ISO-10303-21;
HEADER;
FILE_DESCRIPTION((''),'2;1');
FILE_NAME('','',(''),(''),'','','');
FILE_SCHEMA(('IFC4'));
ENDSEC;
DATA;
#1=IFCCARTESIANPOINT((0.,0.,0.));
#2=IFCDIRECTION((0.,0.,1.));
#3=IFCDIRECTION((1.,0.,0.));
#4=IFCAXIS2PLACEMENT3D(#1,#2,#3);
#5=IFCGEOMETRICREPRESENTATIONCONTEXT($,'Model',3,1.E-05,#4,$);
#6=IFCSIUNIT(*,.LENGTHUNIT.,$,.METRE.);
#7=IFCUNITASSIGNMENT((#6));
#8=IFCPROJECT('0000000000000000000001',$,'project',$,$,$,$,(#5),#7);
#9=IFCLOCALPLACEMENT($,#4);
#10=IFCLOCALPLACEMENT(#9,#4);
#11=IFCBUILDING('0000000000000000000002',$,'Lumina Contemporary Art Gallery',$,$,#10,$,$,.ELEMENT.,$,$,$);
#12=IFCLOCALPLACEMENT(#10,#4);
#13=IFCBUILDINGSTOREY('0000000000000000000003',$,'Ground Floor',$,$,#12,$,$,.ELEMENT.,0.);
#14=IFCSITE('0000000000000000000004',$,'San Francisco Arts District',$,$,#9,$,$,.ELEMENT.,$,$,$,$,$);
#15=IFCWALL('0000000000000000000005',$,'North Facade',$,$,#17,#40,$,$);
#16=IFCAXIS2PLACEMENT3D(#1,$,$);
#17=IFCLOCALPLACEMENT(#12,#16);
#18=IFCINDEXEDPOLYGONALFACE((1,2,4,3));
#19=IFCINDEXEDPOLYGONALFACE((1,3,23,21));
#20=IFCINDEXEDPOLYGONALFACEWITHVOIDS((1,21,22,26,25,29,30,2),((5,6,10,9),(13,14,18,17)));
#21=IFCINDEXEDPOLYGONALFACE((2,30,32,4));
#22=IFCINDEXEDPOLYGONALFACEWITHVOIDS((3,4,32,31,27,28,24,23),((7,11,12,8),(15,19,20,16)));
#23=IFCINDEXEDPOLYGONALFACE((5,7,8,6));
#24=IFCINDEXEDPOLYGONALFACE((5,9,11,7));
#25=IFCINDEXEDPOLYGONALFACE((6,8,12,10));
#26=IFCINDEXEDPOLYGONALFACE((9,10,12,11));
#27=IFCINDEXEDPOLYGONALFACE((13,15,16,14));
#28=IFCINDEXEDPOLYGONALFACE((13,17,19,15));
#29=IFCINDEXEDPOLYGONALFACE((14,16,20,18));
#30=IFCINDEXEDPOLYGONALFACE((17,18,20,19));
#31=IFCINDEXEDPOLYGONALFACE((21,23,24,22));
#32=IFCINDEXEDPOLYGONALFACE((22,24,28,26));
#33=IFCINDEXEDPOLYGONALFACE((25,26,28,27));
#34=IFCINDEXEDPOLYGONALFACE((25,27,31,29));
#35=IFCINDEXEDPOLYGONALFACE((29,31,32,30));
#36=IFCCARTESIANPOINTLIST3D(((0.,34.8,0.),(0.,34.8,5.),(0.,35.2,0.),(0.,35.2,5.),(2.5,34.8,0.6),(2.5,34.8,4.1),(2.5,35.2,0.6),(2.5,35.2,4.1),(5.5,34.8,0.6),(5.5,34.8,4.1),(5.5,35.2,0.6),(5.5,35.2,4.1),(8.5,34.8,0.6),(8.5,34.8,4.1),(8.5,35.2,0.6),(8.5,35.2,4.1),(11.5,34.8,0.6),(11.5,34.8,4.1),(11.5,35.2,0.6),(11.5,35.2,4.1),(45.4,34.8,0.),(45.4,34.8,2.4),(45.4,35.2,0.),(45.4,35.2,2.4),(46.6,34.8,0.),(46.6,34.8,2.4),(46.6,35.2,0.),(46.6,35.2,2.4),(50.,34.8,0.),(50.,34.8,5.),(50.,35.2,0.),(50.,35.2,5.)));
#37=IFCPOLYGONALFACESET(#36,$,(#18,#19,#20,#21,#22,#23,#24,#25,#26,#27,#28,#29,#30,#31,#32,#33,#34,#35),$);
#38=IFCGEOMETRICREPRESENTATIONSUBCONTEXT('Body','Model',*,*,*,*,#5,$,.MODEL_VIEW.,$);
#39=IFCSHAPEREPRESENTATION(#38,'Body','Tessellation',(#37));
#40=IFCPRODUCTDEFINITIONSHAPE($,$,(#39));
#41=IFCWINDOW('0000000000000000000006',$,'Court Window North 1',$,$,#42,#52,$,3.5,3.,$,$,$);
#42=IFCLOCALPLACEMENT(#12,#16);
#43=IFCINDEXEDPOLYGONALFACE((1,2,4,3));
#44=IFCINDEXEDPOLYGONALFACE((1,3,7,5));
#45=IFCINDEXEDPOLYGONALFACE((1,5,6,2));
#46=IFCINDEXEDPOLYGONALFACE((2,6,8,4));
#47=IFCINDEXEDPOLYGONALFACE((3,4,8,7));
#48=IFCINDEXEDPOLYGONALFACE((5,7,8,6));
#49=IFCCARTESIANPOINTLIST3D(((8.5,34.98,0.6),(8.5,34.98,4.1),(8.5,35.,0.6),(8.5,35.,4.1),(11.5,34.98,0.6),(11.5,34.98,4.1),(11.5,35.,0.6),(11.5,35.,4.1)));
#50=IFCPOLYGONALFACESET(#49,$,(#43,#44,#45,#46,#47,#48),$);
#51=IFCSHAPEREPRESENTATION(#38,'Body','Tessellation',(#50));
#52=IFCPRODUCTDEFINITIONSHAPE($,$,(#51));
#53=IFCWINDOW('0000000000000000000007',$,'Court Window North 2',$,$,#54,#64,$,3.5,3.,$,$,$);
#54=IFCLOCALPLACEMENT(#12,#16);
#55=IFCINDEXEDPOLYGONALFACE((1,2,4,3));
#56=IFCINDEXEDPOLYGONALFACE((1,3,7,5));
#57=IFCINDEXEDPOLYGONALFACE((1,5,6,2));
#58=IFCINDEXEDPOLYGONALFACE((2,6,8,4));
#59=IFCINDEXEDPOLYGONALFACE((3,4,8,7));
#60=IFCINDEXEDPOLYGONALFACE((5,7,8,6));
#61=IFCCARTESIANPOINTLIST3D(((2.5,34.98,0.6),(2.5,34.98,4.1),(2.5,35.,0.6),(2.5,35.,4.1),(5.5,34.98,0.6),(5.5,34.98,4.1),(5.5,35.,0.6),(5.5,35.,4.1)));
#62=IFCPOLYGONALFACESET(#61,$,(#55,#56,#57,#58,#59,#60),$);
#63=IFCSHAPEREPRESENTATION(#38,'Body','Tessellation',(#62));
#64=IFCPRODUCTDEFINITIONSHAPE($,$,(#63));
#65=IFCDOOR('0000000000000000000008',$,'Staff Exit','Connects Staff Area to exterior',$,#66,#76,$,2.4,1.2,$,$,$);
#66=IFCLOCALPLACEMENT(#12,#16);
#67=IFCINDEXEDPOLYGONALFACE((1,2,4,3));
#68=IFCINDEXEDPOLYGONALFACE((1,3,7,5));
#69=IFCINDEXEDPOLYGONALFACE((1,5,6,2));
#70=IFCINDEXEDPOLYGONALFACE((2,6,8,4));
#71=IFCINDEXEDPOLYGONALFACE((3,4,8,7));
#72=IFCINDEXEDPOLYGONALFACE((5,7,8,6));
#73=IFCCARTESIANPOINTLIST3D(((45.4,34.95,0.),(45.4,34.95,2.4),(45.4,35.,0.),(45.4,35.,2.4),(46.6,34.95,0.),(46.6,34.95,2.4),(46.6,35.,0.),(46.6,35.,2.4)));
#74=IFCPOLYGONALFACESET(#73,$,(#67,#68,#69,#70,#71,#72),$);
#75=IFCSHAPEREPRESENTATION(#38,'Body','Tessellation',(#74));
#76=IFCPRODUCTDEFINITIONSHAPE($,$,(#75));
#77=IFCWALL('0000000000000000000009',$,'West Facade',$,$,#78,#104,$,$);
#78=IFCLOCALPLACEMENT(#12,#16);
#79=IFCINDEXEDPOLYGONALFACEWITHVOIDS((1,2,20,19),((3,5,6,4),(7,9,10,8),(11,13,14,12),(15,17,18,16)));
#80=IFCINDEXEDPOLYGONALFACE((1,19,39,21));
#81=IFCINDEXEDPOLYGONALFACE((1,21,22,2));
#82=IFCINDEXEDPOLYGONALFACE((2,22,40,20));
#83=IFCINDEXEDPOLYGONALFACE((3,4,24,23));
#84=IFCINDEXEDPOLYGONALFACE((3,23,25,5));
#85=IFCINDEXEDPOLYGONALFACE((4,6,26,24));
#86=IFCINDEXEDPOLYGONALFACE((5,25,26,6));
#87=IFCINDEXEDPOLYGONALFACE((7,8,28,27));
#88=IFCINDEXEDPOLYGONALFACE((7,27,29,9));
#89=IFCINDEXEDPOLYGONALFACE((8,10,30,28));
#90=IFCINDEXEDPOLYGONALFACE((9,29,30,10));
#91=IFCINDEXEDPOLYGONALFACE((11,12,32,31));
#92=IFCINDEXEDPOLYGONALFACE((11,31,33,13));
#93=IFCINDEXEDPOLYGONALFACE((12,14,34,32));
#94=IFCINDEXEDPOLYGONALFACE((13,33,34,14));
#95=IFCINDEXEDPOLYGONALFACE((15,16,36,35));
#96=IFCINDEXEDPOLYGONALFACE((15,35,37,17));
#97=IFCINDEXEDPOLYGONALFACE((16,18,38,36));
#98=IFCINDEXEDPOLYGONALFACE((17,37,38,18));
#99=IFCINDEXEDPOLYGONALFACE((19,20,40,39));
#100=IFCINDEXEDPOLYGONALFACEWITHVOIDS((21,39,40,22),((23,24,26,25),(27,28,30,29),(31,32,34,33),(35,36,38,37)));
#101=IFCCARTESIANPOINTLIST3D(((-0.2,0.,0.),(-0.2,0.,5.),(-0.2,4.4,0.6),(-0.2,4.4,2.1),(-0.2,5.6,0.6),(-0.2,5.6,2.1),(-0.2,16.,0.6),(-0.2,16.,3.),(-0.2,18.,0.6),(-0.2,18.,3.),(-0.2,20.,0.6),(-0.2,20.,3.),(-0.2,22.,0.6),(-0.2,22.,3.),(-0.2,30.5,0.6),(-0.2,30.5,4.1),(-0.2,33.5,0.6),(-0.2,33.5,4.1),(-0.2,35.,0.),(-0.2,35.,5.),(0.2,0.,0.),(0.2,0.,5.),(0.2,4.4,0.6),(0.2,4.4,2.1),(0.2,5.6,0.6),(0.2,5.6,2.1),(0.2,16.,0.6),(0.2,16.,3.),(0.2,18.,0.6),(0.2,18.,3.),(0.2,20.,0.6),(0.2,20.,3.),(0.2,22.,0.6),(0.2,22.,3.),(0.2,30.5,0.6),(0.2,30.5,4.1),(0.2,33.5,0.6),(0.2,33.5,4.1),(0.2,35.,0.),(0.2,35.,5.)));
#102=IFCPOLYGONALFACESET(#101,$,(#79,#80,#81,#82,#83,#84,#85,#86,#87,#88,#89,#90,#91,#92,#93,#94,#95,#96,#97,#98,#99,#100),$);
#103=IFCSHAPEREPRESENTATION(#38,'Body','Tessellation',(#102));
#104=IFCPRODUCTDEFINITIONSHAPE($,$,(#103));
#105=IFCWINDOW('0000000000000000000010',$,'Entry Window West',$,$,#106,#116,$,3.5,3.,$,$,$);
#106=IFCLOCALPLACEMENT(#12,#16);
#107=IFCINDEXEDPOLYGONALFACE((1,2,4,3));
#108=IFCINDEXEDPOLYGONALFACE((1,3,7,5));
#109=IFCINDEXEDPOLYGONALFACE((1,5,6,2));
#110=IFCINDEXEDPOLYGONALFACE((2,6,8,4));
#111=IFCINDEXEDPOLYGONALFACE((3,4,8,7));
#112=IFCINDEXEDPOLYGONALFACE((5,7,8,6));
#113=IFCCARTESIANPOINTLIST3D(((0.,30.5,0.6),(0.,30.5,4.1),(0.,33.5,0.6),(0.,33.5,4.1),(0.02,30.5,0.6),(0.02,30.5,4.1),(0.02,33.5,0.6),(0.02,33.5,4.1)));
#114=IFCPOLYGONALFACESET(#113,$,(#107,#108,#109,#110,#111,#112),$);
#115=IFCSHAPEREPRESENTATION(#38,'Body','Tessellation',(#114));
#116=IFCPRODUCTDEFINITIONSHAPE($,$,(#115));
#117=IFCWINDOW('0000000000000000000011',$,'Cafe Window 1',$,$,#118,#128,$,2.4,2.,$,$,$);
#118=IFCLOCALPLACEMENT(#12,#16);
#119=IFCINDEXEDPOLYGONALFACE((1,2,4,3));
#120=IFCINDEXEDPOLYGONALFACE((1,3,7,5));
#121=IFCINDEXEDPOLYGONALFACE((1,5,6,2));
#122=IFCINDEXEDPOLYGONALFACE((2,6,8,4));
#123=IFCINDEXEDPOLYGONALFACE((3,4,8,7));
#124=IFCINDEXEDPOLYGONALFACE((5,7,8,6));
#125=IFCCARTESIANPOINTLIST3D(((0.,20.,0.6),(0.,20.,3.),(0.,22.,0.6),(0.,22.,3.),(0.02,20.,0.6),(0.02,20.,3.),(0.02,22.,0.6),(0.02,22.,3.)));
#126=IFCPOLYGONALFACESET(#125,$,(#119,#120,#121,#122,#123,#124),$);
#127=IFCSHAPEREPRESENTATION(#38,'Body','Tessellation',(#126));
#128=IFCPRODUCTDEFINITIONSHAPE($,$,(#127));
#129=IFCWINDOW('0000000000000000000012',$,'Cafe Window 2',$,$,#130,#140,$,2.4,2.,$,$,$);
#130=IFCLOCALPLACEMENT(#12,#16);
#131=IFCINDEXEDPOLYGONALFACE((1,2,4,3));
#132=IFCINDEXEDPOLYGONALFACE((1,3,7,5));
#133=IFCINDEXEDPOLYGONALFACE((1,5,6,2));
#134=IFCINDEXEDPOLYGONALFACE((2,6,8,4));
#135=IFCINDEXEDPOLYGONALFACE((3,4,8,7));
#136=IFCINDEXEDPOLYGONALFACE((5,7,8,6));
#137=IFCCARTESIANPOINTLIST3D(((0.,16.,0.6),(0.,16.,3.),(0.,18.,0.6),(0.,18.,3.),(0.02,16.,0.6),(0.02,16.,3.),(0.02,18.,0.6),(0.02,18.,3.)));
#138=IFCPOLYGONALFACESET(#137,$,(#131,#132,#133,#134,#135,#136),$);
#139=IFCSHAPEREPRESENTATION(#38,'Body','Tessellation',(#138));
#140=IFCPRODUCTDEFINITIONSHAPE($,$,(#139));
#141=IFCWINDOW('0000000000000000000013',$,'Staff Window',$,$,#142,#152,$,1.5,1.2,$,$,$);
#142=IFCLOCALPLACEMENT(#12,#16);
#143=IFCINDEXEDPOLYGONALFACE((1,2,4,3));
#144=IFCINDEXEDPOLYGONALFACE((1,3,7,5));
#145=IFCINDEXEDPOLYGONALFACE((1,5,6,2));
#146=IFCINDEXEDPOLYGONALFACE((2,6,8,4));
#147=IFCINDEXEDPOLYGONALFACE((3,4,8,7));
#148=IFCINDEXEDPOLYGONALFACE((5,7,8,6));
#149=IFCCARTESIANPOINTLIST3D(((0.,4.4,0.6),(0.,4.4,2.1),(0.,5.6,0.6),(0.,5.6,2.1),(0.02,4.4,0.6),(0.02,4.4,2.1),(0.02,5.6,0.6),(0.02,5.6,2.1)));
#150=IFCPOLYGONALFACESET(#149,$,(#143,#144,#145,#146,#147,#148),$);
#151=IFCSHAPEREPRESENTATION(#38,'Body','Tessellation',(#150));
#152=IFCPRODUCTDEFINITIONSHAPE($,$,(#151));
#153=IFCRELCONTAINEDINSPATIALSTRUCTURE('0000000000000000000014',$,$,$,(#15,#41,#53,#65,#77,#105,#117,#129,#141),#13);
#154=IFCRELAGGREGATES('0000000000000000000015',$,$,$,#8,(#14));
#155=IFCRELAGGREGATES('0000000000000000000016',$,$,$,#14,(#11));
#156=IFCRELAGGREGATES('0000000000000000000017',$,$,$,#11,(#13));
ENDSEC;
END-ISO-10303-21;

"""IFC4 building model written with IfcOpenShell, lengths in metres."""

from ifc_helpers import new_model, si_unit, origin_with_axes, place, context, subcontext, project, spatial, polyline, outline, extrude, element, fill, save


model = new_model("IFC4")

# Units and contexts
model_context = context("Model", 3, precision=1e-05, world=origin_with_axes())
body_context = subcontext(model_context, "Body", "Model", "MODEL_VIEW")
ifc_project = project(units=[si_unit("LENGTHUNIT", "METRE")], contexts=[model_context])

# Site, building, storey
site_placement = place(None, origin_with_axes())
site = spatial("IfcSite", under=ifc_project, at=site_placement, Name="San Francisco Arts District", CompositionType="ELEMENT")
building_placement = place(site_placement, origin_with_axes())
building = spatial("IfcBuilding", under=site, at=building_placement, Name="Lumina Contemporary Art Gallery", CompositionType="ELEMENT")
storey_placement = place(building_placement, origin_with_axes())
storey = spatial("IfcBuildingStorey", under=building, at=storey_placement, Name="Ground Floor", CompositionType="ELEMENT", Elevation=0.0)

# Wall, openings, windows, door
wall_1_placement = place(storey_placement, origin_with_axes())
wall_1 = element("IfcWall", 1, at=wall_1_placement, inside=storey, Name="North Facade", context=body_context, shape_type="SweptSolid", body=[
    extrude(outline(polyline([(50.0, 35.2, 0.0), (0.0, 35.2, 0.0), (0.0, 34.8, 0.0), (50.0, 34.8, 0.0), (50.0, 35.2, 0.0)])), None, (0.0, 0.0, 1.0), 5.0),
])
opening_1_placement = place(storey_placement, origin_with_axes())
opening_1 = element("IfcOpeningElement", 2, at=opening_1_placement, inside=storey, cuts=wall_1, context=body_context, shape_type="SweptSolid", body=[
    extrude(outline(polyline([(11.5, 35.4, 0.6), (8.5, 35.4, 0.6), (8.5, 34.6, 0.6), (11.5, 34.6, 0.6), (11.5, 35.4, 0.6)])), None, (0.0, 0.0, 1.0), 3.5),
])
opening_2_placement = place(storey_placement, origin_with_axes())
opening_2 = element("IfcOpeningElement", 3, at=opening_2_placement, inside=storey, cuts=wall_1, context=body_context, shape_type="SweptSolid", body=[
    extrude(outline(polyline([(5.5, 35.4, 0.6), (2.5, 35.4, 0.6), (2.5, 34.6, 0.6), (5.5, 34.6, 0.6), (5.5, 35.4, 0.6)])), None, (0.0, 0.0, 1.0), 3.5),
])
opening_3_placement = place(storey_placement, origin_with_axes())
opening_3 = element("IfcOpeningElement", 4, at=opening_3_placement, inside=storey, cuts=wall_1, context=body_context, shape_type="SweptSolid", body=[
    extrude(outline(polyline([(46.6, 35.4, 0.0), (45.4, 35.4, 0.0), (45.4, 34.6, 0.0), (46.6, 34.6, 0.0), (46.6, 35.4, 0.0)])), None, (0.0, 0.0, 1.0), 2.4),
])
window_1_placement = place(storey_placement, origin_with_axes())
window_1 = element("IfcWindow", 5, at=window_1_placement, inside=storey, Name="Court Window North 1", OverallHeight=3.5, OverallWidth=3.0, context=body_context, shape_type="SweptSolid", body=[
    extrude(outline(polyline([(11.5, 35.0, 0.6), (8.5, 35.0, 0.6), (8.5, 34.98, 0.6), (11.5, 34.98, 0.6), (11.5, 35.0, 0.6)])), None, (0.0, 0.0, 1.0), 3.5),
])
fill(opening_1, window_1)
window_2_placement = place(storey_placement, origin_with_axes())
window_2 = element("IfcWindow", 6, at=window_2_placement, inside=storey, Name="Court Window North 2", OverallHeight=3.5, OverallWidth=3.0, context=body_context, shape_type="SweptSolid", body=[
    extrude(outline(polyline([(5.5, 35.0, 0.6), (2.5, 35.0, 0.6), (2.5, 34.98, 0.6), (5.5, 34.98, 0.6), (5.5, 35.0, 0.6)])), None, (0.0, 0.0, 1.0), 3.5),
])
fill(opening_2, window_2)
door_1_placement = place(storey_placement, origin_with_axes())
door_1 = element("IfcDoor", 7, at=door_1_placement, inside=storey, Name="Staff Exit", Description="Connects Staff Area to exterior", OverallHeight=2.4, OverallWidth=1.2, context=body_context, shape_type="SweptSolid", body=[
    extrude(outline(polyline([(46.6, 35.0, 0.0), (45.4, 35.0, 0.0), (45.4, 34.95, 0.0), (46.6, 34.95, 0.0), (46.6, 35.0, 0.0)])), None, (0.0, 0.0, 1.0), 2.4),
])
fill(opening_3, door_1)

# Wall, openings, windows
wall_2_placement = place(storey_placement, origin_with_axes())
wall_2 = element("IfcWall", 8, at=wall_2_placement, inside=storey, Name="West Facade", context=body_context, shape_type="SweptSolid", body=[
    extrude(outline(polyline([(-0.2, 35.0, 0.0), (-0.2, 0.0, 0.0), (0.2, 0.0, 0.0), (0.2, 35.0, 0.0), (-0.2, 35.0, 0.0)])), None, (0.0, 0.0, 1.0), 5.0),
])
opening_4_placement = place(storey_placement, origin_with_axes())
opening_4 = element("IfcOpeningElement", 9, at=opening_4_placement, inside=storey, cuts=wall_2, context=body_context, shape_type="SweptSolid", body=[
    extrude(outline(polyline([(-0.4, 33.5, 0.6), (-0.4, 30.5, 0.6), (0.4, 30.5, 0.6), (0.4, 33.5, 0.6), (-0.4, 33.5, 0.6)])), None, (0.0, 0.0, 1.0), 3.5),
])
opening_5_placement = place(storey_placement, origin_with_axes())
opening_5 = element("IfcOpeningElement", 10, at=opening_5_placement, inside=storey, cuts=wall_2, context=body_context, shape_type="SweptSolid", body=[
    extrude(outline(polyline([(-0.4, 22.0, 0.6), (-0.4, 20.0, 0.6), (0.4, 20.0, 0.6), (0.4, 22.0, 0.6), (-0.4, 22.0, 0.6)])), None, (0.0, 0.0, 1.0), 2.4),
])
opening_6_placement = place(storey_placement, origin_with_axes())
opening_6 = element("IfcOpeningElement", 11, at=opening_6_placement, inside=storey, cuts=wall_2, context=body_context, shape_type="SweptSolid", body=[
    extrude(outline(polyline([(-0.4, 18.0, 0.6), (-0.4, 16.0, 0.6), (0.4, 16.0, 0.6), (0.4, 18.0, 0.6), (-0.4, 18.0, 0.6)])), None, (0.0, 0.0, 1.0), 2.4),
])
opening_7_placement = place(storey_placement, origin_with_axes())
opening_7 = element("IfcOpeningElement", 12, at=opening_7_placement, inside=storey, cuts=wall_2, context=body_context, shape_type="SweptSolid", body=[
    extrude(outline(polyline([(-0.4, 5.6, 0.6), (-0.4, 4.4, 0.6), (0.4, 4.4, 0.6), (0.4, 5.6, 0.6), (-0.4, 5.6, 0.6)])), None, (0.0, 0.0, 1.0), 1.5),
])
window_3_placement = place(storey_placement, origin_with_axes())
window_3 = element("IfcWindow", 13, at=window_3_placement, inside=storey, Name="Entry Window West", OverallHeight=3.5, OverallWidth=3.0, context=body_context, shape_type="SweptSolid", body=[
    extrude(outline(polyline([(0.0, 33.5, 0.6), (0.0, 30.5, 0.6), (0.02, 30.5, 0.6), (0.02, 33.5, 0.6), (0.0, 33.5, 0.6)])), None, (0.0, 0.0, 1.0), 3.5),
])
fill(opening_4, window_3)
window_4_placement = place(storey_placement, origin_with_axes())
window_4 = element("IfcWindow", 14, at=window_4_placement, inside=storey, Name="Cafe Window 1", OverallHeight=2.4, OverallWidth=2.0, context=body_context, shape_type="SweptSolid", body=[
    extrude(outline(polyline([(0.0, 22.0, 0.6), (0.0, 20.0, 0.6), (0.02, 20.0, 0.6), (0.02, 22.0, 0.6), (0.0, 22.0, 0.6)])), None, (0.0, 0.0, 1.0), 2.4),
])
fill(opening_5, window_4)
window_5_placement = place(storey_placement, origin_with_axes())
window_5 = element("IfcWindow", 15, at=window_5_placement, inside=storey, Name="Cafe Window 2", OverallHeight=2.4, OverallWidth=2.0, context=body_context, shape_type="SweptSolid", body=[
    extrude(outline(polyline([(0.0, 18.0, 0.6), (0.0, 16.0, 0.6), (0.02, 16.0, 0.6), (0.02, 18.0, 0.6), (0.0, 18.0, 0.6)])), None, (0.0, 0.0, 1.0), 2.4),
])
fill(opening_6, window_5)
window_6_placement = place(storey_placement, origin_with_axes())
window_6 = element("IfcWindow", 16, at=window_6_placement, inside=storey, Name="Staff Window", OverallHeight=1.5, OverallWidth=1.2, context=body_context, shape_type="SweptSolid", body=[
    extrude(outline(polyline([(0.0, 5.6, 0.6), (0.0, 4.4, 0.6), (0.02, 4.4, 0.6), (0.02, 5.6, 0.6), (0.0, 5.6, 0.6)])), None, (0.0, 0.0, 1.0), 1.5),
])
fill(opening_7, window_6)

save(model, "model.ifc")
